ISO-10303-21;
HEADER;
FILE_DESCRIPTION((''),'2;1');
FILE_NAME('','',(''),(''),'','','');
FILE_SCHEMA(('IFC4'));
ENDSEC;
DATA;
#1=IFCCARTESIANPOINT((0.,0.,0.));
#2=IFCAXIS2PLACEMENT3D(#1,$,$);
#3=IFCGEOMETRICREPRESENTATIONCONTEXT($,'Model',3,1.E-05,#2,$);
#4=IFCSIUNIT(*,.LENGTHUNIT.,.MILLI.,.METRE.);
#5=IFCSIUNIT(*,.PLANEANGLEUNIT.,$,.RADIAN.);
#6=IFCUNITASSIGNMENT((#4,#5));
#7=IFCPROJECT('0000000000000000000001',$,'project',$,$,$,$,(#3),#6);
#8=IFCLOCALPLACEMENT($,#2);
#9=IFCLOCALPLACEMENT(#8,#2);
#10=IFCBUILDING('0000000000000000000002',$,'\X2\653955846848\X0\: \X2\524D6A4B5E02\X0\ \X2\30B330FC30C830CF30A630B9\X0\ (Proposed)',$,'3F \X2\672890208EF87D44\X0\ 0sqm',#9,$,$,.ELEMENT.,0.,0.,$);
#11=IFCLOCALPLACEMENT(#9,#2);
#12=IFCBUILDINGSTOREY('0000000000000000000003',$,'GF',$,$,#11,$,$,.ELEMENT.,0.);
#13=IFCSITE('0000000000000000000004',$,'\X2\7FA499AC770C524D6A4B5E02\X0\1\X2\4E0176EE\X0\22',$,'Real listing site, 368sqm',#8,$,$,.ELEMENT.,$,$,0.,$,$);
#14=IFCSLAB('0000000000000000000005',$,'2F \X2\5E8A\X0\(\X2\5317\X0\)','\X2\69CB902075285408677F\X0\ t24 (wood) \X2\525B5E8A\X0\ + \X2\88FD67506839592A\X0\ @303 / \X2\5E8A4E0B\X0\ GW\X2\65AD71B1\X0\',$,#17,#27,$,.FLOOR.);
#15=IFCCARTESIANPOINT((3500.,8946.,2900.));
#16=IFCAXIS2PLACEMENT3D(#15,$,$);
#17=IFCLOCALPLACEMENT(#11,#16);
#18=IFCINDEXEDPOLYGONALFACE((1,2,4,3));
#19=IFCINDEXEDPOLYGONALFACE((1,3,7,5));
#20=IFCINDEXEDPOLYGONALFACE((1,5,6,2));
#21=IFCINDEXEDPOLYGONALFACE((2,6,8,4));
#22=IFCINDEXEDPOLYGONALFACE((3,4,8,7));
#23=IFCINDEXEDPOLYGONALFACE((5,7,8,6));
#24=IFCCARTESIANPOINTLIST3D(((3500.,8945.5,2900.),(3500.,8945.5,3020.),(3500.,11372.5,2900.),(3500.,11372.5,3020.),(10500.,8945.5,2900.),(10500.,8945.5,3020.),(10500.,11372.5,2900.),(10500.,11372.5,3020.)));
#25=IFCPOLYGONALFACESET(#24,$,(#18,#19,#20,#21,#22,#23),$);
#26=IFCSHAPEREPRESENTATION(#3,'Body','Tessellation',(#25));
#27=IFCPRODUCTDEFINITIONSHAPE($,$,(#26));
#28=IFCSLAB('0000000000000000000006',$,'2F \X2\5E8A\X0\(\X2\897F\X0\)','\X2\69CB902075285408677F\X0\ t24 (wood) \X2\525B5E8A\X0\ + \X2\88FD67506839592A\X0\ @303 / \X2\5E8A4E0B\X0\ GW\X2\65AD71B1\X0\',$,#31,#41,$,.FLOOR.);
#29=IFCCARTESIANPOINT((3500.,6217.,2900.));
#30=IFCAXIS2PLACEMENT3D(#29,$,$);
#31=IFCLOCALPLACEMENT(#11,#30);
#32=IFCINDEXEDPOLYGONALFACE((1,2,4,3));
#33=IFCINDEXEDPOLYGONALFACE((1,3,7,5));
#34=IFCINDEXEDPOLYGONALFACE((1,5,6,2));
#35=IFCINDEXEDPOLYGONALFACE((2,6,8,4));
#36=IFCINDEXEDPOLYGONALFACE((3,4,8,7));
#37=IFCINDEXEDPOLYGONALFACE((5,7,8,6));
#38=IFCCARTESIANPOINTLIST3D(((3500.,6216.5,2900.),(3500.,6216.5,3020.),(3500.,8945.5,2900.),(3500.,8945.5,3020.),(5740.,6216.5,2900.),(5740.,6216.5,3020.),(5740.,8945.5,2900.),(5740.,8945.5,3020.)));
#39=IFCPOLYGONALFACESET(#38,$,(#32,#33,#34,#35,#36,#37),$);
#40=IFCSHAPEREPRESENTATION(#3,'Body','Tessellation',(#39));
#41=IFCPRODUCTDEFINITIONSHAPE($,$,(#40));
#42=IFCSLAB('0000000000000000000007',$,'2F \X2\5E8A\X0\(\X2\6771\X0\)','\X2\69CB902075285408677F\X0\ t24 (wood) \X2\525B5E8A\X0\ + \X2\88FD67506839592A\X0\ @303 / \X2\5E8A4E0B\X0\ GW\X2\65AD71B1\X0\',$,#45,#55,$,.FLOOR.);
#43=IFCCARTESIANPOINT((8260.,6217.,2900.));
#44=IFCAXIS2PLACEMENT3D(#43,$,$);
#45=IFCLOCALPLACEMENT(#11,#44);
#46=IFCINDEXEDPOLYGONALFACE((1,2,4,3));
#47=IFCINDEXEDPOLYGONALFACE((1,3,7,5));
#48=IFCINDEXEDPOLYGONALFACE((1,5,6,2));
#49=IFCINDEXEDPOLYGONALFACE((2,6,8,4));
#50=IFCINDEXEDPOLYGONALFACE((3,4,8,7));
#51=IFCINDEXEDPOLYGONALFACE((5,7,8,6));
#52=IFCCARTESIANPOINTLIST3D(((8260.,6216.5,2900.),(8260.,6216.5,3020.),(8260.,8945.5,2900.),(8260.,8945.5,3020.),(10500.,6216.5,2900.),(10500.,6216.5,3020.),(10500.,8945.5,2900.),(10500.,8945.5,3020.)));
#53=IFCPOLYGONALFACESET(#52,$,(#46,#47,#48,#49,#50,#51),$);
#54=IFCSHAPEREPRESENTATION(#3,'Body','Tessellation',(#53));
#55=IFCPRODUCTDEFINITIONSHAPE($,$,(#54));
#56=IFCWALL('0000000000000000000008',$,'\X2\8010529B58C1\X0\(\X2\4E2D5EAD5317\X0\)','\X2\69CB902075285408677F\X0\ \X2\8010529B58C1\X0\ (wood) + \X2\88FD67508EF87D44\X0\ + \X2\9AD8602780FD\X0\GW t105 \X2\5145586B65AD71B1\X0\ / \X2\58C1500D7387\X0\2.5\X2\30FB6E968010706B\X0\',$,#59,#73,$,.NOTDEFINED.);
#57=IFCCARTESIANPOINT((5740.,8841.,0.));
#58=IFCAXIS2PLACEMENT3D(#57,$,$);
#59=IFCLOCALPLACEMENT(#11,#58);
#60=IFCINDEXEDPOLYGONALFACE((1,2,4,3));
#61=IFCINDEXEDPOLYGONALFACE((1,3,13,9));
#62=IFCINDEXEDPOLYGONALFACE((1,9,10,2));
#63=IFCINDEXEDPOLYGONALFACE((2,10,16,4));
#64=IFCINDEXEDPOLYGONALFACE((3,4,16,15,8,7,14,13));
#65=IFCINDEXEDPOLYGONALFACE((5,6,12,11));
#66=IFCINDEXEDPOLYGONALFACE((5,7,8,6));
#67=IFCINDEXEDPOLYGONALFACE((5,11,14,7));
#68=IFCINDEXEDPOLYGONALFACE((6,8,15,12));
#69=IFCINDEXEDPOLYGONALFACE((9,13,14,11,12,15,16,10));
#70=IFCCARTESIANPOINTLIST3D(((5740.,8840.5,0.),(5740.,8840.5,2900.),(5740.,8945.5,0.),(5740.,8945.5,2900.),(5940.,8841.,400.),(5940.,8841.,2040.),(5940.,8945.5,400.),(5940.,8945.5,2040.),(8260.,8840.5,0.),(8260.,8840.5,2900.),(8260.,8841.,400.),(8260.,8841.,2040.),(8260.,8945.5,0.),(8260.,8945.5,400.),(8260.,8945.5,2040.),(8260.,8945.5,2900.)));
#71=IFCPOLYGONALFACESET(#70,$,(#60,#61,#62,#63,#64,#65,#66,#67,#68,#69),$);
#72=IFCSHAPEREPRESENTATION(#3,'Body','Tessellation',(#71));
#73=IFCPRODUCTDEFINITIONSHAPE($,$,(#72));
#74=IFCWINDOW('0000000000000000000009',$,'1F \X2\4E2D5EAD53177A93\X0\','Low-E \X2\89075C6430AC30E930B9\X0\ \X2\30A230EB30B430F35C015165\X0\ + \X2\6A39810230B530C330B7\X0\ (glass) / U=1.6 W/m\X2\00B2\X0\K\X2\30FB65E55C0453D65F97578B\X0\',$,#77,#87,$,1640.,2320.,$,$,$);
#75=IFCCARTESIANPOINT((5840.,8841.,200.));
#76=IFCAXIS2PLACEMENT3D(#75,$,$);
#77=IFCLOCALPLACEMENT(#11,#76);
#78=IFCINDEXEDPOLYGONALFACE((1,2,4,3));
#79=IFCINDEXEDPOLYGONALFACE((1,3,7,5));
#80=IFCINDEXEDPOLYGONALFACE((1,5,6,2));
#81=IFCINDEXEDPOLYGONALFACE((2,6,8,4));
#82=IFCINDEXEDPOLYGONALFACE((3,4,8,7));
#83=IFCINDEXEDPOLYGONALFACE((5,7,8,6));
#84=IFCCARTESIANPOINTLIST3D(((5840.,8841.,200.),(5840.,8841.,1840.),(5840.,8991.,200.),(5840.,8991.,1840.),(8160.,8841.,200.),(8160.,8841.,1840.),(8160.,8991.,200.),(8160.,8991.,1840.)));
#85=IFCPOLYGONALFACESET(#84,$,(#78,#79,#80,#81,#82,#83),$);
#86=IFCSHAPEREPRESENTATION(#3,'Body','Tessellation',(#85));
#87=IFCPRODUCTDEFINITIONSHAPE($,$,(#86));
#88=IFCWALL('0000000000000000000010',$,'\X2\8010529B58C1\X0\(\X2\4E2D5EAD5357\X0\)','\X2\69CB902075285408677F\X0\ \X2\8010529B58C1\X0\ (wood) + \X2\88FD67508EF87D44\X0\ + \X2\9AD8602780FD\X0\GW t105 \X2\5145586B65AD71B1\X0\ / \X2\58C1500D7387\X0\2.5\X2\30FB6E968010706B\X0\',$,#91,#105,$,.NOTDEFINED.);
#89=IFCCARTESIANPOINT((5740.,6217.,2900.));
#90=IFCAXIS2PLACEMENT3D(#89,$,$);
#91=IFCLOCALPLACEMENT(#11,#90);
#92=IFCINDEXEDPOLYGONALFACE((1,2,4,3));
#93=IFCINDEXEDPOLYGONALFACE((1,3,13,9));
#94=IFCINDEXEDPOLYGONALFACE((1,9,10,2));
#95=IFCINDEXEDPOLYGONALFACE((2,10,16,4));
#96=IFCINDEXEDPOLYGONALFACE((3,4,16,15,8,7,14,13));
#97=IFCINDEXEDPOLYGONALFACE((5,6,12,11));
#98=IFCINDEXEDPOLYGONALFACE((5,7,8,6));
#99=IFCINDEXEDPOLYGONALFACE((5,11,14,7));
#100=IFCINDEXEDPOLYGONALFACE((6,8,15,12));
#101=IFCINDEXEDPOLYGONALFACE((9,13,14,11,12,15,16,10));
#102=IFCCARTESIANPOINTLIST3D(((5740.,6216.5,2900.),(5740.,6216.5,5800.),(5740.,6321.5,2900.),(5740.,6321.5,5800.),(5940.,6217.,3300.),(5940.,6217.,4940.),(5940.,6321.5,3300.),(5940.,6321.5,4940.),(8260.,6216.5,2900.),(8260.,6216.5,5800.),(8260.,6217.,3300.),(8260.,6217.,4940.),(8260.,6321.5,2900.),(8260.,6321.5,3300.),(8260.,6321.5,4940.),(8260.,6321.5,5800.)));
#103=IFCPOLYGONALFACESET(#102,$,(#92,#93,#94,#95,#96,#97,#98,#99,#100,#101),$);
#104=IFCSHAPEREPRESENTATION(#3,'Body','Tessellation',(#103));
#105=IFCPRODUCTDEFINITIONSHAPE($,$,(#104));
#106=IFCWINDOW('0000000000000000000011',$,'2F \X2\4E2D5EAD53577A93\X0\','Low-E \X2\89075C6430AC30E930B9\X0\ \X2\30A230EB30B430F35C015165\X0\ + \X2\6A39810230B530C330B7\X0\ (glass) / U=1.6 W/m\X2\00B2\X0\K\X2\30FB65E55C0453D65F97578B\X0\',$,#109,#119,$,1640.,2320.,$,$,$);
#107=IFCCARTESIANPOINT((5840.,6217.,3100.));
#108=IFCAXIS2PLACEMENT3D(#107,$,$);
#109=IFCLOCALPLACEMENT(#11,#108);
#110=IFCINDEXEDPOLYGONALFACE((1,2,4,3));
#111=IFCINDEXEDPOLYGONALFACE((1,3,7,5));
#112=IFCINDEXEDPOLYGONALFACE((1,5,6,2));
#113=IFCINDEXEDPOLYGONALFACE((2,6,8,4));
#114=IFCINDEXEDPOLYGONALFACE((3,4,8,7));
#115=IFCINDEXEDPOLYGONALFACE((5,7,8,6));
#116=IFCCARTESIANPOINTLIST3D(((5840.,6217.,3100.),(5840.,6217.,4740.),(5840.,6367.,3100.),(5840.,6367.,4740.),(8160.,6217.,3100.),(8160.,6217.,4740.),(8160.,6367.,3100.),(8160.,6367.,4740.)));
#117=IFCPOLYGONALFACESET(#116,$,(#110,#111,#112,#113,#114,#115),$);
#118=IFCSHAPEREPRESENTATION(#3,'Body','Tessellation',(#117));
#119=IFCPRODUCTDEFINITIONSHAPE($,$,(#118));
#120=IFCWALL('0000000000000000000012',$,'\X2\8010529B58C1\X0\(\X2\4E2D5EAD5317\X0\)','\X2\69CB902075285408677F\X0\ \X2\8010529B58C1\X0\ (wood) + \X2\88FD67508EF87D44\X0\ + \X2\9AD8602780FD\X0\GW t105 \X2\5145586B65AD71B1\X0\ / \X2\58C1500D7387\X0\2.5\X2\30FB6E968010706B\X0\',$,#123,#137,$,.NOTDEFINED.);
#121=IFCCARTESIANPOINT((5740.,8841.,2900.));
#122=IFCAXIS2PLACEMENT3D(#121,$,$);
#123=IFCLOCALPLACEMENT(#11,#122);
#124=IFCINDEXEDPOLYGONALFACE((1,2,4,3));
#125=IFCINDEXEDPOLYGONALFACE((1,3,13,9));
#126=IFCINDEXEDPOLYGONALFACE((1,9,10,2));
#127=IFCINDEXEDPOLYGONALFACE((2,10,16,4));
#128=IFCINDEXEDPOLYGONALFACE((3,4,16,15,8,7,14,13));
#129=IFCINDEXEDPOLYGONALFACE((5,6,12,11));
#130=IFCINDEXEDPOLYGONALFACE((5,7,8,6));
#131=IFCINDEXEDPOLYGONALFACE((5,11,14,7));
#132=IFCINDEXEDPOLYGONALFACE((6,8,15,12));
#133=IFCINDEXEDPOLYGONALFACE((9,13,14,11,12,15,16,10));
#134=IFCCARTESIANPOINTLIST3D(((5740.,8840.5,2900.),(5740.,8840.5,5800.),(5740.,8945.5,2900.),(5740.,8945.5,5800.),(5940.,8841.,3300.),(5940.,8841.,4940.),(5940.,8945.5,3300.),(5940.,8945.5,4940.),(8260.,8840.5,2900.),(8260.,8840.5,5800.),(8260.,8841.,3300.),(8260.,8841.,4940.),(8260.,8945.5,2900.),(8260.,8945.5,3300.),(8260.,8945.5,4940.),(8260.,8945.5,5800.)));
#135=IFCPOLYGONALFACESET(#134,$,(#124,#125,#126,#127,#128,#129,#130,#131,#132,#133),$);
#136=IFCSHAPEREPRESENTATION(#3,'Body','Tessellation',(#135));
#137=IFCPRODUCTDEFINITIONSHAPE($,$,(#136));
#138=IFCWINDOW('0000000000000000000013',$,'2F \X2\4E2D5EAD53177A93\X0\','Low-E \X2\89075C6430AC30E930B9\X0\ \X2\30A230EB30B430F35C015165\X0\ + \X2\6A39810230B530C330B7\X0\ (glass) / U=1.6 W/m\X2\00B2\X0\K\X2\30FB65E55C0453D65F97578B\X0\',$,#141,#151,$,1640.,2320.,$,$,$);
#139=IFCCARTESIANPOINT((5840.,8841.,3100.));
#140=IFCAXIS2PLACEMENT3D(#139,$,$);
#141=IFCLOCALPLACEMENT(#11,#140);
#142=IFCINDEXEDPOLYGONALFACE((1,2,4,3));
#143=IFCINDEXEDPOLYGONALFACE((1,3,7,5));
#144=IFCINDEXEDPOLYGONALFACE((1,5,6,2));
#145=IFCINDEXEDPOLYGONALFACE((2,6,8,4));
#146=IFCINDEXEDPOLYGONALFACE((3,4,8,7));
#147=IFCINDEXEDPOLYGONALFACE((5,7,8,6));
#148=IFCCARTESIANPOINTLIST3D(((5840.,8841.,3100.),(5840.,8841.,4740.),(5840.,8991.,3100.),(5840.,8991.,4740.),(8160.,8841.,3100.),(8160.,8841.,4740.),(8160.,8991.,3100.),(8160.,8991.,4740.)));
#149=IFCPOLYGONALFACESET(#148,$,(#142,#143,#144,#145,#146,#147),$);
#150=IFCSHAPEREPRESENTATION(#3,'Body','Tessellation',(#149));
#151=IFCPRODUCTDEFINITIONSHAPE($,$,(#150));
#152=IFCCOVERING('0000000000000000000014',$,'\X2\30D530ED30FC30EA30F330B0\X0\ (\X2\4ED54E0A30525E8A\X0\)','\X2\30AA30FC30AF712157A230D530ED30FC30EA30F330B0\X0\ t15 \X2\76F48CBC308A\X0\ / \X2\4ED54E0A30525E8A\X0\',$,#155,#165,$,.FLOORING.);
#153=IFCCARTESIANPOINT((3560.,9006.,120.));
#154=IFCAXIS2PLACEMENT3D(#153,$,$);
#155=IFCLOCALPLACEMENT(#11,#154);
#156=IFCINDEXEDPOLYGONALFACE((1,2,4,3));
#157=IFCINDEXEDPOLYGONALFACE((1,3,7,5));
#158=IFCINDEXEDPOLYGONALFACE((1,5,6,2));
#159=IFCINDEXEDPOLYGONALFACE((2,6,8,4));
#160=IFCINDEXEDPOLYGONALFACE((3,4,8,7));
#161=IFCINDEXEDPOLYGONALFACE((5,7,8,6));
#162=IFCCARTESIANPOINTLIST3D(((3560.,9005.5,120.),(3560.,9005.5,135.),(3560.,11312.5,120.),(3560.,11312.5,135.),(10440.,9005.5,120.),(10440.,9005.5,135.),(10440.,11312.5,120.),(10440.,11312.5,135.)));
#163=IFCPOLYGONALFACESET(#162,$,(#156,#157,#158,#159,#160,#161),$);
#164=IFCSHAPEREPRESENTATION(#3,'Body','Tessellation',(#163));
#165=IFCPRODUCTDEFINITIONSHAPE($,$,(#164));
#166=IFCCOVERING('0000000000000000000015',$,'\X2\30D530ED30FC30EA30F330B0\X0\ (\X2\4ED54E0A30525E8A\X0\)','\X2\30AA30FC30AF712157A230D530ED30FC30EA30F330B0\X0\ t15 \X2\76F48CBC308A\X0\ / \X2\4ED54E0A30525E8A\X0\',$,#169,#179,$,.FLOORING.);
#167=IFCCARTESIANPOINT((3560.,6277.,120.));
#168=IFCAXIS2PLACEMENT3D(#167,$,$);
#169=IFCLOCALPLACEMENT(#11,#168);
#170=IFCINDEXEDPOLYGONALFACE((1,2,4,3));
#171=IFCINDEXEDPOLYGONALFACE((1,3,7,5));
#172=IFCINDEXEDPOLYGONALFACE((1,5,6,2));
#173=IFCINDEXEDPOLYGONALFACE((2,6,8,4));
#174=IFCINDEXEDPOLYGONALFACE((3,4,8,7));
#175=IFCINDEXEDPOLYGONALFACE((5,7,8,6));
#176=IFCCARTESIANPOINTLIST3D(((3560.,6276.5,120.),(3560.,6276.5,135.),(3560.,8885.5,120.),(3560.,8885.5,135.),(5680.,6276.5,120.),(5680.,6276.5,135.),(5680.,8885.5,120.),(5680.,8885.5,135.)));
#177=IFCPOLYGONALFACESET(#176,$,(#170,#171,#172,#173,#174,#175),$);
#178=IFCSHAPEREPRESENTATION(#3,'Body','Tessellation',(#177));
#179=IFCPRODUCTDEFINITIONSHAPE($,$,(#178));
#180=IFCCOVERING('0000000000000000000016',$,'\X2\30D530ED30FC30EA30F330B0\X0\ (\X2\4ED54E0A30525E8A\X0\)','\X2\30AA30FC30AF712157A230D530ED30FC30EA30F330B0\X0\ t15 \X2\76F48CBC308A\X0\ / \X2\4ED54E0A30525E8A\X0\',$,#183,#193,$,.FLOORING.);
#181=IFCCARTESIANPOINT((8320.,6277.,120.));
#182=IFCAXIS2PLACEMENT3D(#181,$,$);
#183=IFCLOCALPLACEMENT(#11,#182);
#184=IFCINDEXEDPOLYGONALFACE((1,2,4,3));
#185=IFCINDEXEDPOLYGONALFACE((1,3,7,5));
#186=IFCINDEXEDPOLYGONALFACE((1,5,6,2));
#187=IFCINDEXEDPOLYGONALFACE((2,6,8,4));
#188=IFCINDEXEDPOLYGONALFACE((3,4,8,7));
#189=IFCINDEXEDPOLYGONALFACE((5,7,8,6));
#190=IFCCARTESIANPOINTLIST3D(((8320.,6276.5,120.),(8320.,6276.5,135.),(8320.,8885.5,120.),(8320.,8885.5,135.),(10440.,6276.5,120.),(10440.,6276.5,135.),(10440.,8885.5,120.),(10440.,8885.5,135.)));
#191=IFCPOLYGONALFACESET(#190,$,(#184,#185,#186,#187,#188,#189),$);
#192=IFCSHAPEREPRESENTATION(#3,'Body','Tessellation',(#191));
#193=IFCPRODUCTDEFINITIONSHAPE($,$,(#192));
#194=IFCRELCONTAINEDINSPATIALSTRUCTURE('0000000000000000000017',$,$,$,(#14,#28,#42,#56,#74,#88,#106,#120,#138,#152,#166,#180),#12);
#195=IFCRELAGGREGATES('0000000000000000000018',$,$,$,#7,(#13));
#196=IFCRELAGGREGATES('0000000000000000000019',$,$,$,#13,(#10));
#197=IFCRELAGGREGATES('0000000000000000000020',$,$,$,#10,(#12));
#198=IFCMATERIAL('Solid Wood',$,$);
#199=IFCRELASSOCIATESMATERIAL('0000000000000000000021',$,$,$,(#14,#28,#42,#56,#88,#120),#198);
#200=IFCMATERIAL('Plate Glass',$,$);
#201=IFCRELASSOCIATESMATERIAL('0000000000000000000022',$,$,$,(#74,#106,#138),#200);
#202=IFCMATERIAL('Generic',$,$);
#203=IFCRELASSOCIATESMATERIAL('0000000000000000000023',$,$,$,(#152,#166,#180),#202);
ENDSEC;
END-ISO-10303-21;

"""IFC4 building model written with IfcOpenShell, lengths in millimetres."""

from ifc_helpers import new_model, si_unit, frame, frame_2d, origin, place, context, project, spatial, rectangle, extrude, material, element, fill, save


model = new_model("IFC4")

# Units and contexts
model_context = context("Model", 3, precision=1e-05, world=origin())
ifc_project = project(units=[si_unit("LENGTHUNIT", "METRE", prefix="MILLI"), si_unit("PLANEANGLEUNIT", "RADIAN")], contexts=[model_context])

# Site, building, storey
site_placement = place(None, origin())
site = spatial("IfcSite", under=ifc_project, at=site_placement, Name="群馬県前橋市1丁目22", ObjectType="Real listing site, 368sqm", CompositionType="ELEMENT", RefElevation=0.0)
building_placement = place(site_placement, origin())
building = spatial("IfcBuilding", under=site, at=building_placement, Name="改善案: 前橋市 コートハウス (Proposed)", ObjectType="3F 木造軸組 0sqm", CompositionType="ELEMENT", ElevationOfRefHeight=0.0, ElevationOfTerrain=0.0)
storey_placement = place(building_placement, origin())
storey = spatial("IfcBuildingStorey", under=building, at=storey_placement, Name="GF", CompositionType="ELEMENT", Elevation=0.0)

# Slabs
ifc_material_1 = material(Name="Solid Wood")
slab_1_placement = place(storey_placement, frame((3500.0, 8946.0, 2900.0)))
element("IfcSlab", 1, at=slab_1_placement, inside=storey, material=ifc_material_1, Name="2F 床(北)", Description="構造用合板 t24 (wood) 剛床 + 製材根太 @303 / 床下 GW断熱", PredefinedType="FLOOR", context=model_context, shape_type="SweptSolid", body=[
    extrude(rectangle(XDim=7000.0, YDim=2427.0, at=frame_2d((3500.0, 1213.0))), frame((3500.0, 8946.0, 2900.0)), (0.0, 0.0, 1.0), 120.0),
])
slab_2_placement = place(storey_placement, frame((3500.0, 6217.0, 2900.0)))
element("IfcSlab", 2, at=slab_2_placement, inside=storey, material=ifc_material_1, Name="2F 床(西)", Description="構造用合板 t24 (wood) 剛床 + 製材根太 @303 / 床下 GW断熱", PredefinedType="FLOOR", context=model_context, shape_type="SweptSolid", body=[
    extrude(rectangle(XDim=2240.0, YDim=2729.0, at=frame_2d((1120.0, 1364.0))), frame((3500.0, 6217.0, 2900.0)), (0.0, 0.0, 1.0), 120.0),
])
slab_3_placement = place(storey_placement, frame((8260.0, 6217.0, 2900.0)))
element("IfcSlab", 3, at=slab_3_placement, inside=storey, material=ifc_material_1, Name="2F 床(東)", Description="構造用合板 t24 (wood) 剛床 + 製材根太 @303 / 床下 GW断熱", PredefinedType="FLOOR", context=model_context, shape_type="SweptSolid", body=[
    extrude(rectangle(XDim=2240.0, YDim=2729.0, at=frame_2d((1120.0, 1364.0))), frame((8260.0, 6217.0, 2900.0)), (0.0, 0.0, 1.0), 120.0),
])

# Wall, opening, window
wall_1_placement = place(storey_placement, frame((5740.0, 8841.0, 0.0)))
wall_1 = element("IfcWall", 4, at=wall_1_placement, inside=storey, material=ifc_material_1, Name="耐力壁(中庭北)", Description="構造用合板 耐力壁 (wood) + 製材軸組 + 高性能GW t105 充填断熱 / 壁倍率2.5・準耐火", PredefinedType="NOTDEFINED", context=model_context, shape_type="SweptSolid", body=[
    extrude(rectangle(XDim=2520.0, YDim=105.0, at=frame_2d((1260.0, 52.0))), frame((5740.0, 8841.0, 0.0)), (0.0, 0.0, 1.0), 2900.0),
])
opening_1_placement = place(storey_placement, frame((5840.0, 8841.0, 200.0)))
opening_1 = element("IfcOpeningElement", 5, at=opening_1_placement, cuts=wall_1, PredefinedType="NOTDEFINED", context=model_context, shape_type="SweptSolid", body=[
    extrude(rectangle(XDim=2320.0, YDim=150.0, at=frame_2d((1160.0, 75.0))), frame((5840.0, 8841.0, 200.0)), (0.0, 0.0, 1.0), 1640.0),
])
ifc_material_2 = material(Name="Plate Glass")
window_1_placement = place(storey_placement, frame((5840.0, 8841.0, 200.0)))
window_1 = element("IfcWindow", 6, at=window_1_placement, inside=storey, material=ifc_material_2, Name="1F 中庭北窓", Description="Low-E 複層ガラス アルゴン封入 + 樹脂サッシ (glass) / U=1.6 W/m²K・日射取得型", OverallHeight=1640.0, OverallWidth=2320.0, context=model_context, shape_type="SweptSolid", body=[
    extrude(rectangle(XDim=2320.0, YDim=150.0, at=frame_2d((1160.0, 75.0))), frame((5840.0, 8841.0, 200.0)), (0.0, 0.0, 1.0), 1640.0),
])
fill(opening_1, window_1)

# Walls, openings, windows
wall_2_placement = place(storey_placement, frame((5740.0, 6217.0, 2900.0)))
wall_2 = element("IfcWall", 7, at=wall_2_placement, inside=storey, material=ifc_material_1, Name="耐力壁(中庭南)", Description="構造用合板 耐力壁 (wood) + 製材軸組 + 高性能GW t105 充填断熱 / 壁倍率2.5・準耐火", PredefinedType="NOTDEFINED", context=model_context, shape_type="SweptSolid", body=[
    extrude(rectangle(XDim=2520.0, YDim=105.0, at=frame_2d((1260.0, 52.0))), frame((5740.0, 6217.0, 2900.0)), (0.0, 0.0, 1.0), 2900.0),
])
opening_2_placement = place(storey_placement, frame((5840.0, 6217.0, 3100.0)))
opening_2 = element("IfcOpeningElement", 8, at=opening_2_placement, cuts=wall_2, PredefinedType="NOTDEFINED", context=model_context, shape_type="SweptSolid", body=[
    extrude(rectangle(XDim=2320.0, YDim=150.0, at=frame_2d((1160.0, 75.0))), frame((5840.0, 6217.0, 3100.0)), (0.0, 0.0, 1.0), 1640.0),
])
window_2_placement = place(storey_placement, frame((5840.0, 6217.0, 3100.0)))
window_2 = element("IfcWindow", 9, at=window_2_placement, inside=storey, material=ifc_material_2, Name="2F 中庭南窓", Description="Low-E 複層ガラス アルゴン封入 + 樹脂サッシ (glass) / U=1.6 W/m²K・日射取得型", OverallHeight=1640.0, OverallWidth=2320.0, context=model_context, shape_type="SweptSolid", body=[
    extrude(rectangle(XDim=2320.0, YDim=150.0, at=frame_2d((1160.0, 75.0))), frame((5840.0, 6217.0, 3100.0)), (0.0, 0.0, 1.0), 1640.0),
])
fill(opening_2, window_2)
wall_3_placement = place(storey_placement, frame((5740.0, 8841.0, 2900.0)))
wall_3 = element("IfcWall", 10, at=wall_3_placement, inside=storey, material=ifc_material_1, Name="耐力壁(中庭北)", Description="構造用合板 耐力壁 (wood) + 製材軸組 + 高性能GW t105 充填断熱 / 壁倍率2.5・準耐火", PredefinedType="NOTDEFINED", context=model_context, shape_type="SweptSolid", body=[
    extrude(rectangle(XDim=2520.0, YDim=105.0, at=frame_2d((1260.0, 52.0))), frame((5740.0, 8841.0, 2900.0)), (0.0, 0.0, 1.0), 2900.0),
])
opening_3_placement = place(storey_placement, frame((5840.0, 8841.0, 3100.0)))
opening_3 = element("IfcOpeningElement", 11, at=opening_3_placement, cuts=wall_3, PredefinedType="NOTDEFINED", context=model_context, shape_type="SweptSolid", body=[
    extrude(rectangle(XDim=2320.0, YDim=150.0, at=frame_2d((1160.0, 75.0))), frame((5840.0, 8841.0, 3100.0)), (0.0, 0.0, 1.0), 1640.0),
])
window_3_placement = place(storey_placement, frame((5840.0, 8841.0, 3100.0)))
window_3 = element("IfcWindow", 12, at=window_3_placement, inside=storey, material=ifc_material_2, Name="2F 中庭北窓", Description="Low-E 複層ガラス アルゴン封入 + 樹脂サッシ (glass) / U=1.6 W/m²K・日射取得型", OverallHeight=1640.0, OverallWidth=2320.0, context=model_context, shape_type="SweptSolid", body=[
    extrude(rectangle(XDim=2320.0, YDim=150.0, at=frame_2d((1160.0, 75.0))), frame((5840.0, 8841.0, 3100.0)), (0.0, 0.0, 1.0), 1640.0),
])
fill(opening_3, window_3)

# Coverings
ifc_material_3 = material(Name="Generic")
covering_1_placement = place(storey_placement, frame((3560.0, 9006.0, 120.0)))
element("IfcCovering", 13, at=covering_1_placement, inside=storey, material=ifc_material_3, Name="フローリング (仕上げ床)", Description="オーク無垢フローリング t15 直貼り / 仕上げ床", PredefinedType="FLOORING", context=model_context, shape_type="SweptSolid", body=[
    extrude(rectangle(XDim=6880.0, YDim=2307.0, at=frame_2d((3440.0, 1153.0))), frame((3560.0, 9006.0, 120.0)), (0.0, 0.0, 1.0), 15.0),
])
covering_2_placement = place(storey_placement, frame((3560.0, 6277.0, 120.0)))
element("IfcCovering", 14, at=covering_2_placement, inside=storey, material=ifc_material_3, Name="フローリング (仕上げ床)", Description="オーク無垢フローリング t15 直貼り / 仕上げ床", PredefinedType="FLOORING", context=model_context, shape_type="SweptSolid", body=[
    extrude(rectangle(XDim=2120.0, YDim=2609.0, at=frame_2d((1060.0, 1304.0))), frame((3560.0, 6277.0, 120.0)), (0.0, 0.0, 1.0), 15.0),
])
covering_3_placement = place(storey_placement, frame((8320.0, 6277.0, 120.0)))
element("IfcCovering", 15, at=covering_3_placement, inside=storey, material=ifc_material_3, Name="フローリング (仕上げ床)", Description="オーク無垢フローリング t15 直貼り / 仕上げ床", PredefinedType="FLOORING", context=model_context, shape_type="SweptSolid", body=[
    extrude(rectangle(XDim=2120.0, YDim=2609.0, at=frame_2d((1060.0, 1304.0))), frame((8320.0, 6277.0, 120.0)), (0.0, 0.0, 1.0), 15.0),
])

save(model, "model.ifc")
